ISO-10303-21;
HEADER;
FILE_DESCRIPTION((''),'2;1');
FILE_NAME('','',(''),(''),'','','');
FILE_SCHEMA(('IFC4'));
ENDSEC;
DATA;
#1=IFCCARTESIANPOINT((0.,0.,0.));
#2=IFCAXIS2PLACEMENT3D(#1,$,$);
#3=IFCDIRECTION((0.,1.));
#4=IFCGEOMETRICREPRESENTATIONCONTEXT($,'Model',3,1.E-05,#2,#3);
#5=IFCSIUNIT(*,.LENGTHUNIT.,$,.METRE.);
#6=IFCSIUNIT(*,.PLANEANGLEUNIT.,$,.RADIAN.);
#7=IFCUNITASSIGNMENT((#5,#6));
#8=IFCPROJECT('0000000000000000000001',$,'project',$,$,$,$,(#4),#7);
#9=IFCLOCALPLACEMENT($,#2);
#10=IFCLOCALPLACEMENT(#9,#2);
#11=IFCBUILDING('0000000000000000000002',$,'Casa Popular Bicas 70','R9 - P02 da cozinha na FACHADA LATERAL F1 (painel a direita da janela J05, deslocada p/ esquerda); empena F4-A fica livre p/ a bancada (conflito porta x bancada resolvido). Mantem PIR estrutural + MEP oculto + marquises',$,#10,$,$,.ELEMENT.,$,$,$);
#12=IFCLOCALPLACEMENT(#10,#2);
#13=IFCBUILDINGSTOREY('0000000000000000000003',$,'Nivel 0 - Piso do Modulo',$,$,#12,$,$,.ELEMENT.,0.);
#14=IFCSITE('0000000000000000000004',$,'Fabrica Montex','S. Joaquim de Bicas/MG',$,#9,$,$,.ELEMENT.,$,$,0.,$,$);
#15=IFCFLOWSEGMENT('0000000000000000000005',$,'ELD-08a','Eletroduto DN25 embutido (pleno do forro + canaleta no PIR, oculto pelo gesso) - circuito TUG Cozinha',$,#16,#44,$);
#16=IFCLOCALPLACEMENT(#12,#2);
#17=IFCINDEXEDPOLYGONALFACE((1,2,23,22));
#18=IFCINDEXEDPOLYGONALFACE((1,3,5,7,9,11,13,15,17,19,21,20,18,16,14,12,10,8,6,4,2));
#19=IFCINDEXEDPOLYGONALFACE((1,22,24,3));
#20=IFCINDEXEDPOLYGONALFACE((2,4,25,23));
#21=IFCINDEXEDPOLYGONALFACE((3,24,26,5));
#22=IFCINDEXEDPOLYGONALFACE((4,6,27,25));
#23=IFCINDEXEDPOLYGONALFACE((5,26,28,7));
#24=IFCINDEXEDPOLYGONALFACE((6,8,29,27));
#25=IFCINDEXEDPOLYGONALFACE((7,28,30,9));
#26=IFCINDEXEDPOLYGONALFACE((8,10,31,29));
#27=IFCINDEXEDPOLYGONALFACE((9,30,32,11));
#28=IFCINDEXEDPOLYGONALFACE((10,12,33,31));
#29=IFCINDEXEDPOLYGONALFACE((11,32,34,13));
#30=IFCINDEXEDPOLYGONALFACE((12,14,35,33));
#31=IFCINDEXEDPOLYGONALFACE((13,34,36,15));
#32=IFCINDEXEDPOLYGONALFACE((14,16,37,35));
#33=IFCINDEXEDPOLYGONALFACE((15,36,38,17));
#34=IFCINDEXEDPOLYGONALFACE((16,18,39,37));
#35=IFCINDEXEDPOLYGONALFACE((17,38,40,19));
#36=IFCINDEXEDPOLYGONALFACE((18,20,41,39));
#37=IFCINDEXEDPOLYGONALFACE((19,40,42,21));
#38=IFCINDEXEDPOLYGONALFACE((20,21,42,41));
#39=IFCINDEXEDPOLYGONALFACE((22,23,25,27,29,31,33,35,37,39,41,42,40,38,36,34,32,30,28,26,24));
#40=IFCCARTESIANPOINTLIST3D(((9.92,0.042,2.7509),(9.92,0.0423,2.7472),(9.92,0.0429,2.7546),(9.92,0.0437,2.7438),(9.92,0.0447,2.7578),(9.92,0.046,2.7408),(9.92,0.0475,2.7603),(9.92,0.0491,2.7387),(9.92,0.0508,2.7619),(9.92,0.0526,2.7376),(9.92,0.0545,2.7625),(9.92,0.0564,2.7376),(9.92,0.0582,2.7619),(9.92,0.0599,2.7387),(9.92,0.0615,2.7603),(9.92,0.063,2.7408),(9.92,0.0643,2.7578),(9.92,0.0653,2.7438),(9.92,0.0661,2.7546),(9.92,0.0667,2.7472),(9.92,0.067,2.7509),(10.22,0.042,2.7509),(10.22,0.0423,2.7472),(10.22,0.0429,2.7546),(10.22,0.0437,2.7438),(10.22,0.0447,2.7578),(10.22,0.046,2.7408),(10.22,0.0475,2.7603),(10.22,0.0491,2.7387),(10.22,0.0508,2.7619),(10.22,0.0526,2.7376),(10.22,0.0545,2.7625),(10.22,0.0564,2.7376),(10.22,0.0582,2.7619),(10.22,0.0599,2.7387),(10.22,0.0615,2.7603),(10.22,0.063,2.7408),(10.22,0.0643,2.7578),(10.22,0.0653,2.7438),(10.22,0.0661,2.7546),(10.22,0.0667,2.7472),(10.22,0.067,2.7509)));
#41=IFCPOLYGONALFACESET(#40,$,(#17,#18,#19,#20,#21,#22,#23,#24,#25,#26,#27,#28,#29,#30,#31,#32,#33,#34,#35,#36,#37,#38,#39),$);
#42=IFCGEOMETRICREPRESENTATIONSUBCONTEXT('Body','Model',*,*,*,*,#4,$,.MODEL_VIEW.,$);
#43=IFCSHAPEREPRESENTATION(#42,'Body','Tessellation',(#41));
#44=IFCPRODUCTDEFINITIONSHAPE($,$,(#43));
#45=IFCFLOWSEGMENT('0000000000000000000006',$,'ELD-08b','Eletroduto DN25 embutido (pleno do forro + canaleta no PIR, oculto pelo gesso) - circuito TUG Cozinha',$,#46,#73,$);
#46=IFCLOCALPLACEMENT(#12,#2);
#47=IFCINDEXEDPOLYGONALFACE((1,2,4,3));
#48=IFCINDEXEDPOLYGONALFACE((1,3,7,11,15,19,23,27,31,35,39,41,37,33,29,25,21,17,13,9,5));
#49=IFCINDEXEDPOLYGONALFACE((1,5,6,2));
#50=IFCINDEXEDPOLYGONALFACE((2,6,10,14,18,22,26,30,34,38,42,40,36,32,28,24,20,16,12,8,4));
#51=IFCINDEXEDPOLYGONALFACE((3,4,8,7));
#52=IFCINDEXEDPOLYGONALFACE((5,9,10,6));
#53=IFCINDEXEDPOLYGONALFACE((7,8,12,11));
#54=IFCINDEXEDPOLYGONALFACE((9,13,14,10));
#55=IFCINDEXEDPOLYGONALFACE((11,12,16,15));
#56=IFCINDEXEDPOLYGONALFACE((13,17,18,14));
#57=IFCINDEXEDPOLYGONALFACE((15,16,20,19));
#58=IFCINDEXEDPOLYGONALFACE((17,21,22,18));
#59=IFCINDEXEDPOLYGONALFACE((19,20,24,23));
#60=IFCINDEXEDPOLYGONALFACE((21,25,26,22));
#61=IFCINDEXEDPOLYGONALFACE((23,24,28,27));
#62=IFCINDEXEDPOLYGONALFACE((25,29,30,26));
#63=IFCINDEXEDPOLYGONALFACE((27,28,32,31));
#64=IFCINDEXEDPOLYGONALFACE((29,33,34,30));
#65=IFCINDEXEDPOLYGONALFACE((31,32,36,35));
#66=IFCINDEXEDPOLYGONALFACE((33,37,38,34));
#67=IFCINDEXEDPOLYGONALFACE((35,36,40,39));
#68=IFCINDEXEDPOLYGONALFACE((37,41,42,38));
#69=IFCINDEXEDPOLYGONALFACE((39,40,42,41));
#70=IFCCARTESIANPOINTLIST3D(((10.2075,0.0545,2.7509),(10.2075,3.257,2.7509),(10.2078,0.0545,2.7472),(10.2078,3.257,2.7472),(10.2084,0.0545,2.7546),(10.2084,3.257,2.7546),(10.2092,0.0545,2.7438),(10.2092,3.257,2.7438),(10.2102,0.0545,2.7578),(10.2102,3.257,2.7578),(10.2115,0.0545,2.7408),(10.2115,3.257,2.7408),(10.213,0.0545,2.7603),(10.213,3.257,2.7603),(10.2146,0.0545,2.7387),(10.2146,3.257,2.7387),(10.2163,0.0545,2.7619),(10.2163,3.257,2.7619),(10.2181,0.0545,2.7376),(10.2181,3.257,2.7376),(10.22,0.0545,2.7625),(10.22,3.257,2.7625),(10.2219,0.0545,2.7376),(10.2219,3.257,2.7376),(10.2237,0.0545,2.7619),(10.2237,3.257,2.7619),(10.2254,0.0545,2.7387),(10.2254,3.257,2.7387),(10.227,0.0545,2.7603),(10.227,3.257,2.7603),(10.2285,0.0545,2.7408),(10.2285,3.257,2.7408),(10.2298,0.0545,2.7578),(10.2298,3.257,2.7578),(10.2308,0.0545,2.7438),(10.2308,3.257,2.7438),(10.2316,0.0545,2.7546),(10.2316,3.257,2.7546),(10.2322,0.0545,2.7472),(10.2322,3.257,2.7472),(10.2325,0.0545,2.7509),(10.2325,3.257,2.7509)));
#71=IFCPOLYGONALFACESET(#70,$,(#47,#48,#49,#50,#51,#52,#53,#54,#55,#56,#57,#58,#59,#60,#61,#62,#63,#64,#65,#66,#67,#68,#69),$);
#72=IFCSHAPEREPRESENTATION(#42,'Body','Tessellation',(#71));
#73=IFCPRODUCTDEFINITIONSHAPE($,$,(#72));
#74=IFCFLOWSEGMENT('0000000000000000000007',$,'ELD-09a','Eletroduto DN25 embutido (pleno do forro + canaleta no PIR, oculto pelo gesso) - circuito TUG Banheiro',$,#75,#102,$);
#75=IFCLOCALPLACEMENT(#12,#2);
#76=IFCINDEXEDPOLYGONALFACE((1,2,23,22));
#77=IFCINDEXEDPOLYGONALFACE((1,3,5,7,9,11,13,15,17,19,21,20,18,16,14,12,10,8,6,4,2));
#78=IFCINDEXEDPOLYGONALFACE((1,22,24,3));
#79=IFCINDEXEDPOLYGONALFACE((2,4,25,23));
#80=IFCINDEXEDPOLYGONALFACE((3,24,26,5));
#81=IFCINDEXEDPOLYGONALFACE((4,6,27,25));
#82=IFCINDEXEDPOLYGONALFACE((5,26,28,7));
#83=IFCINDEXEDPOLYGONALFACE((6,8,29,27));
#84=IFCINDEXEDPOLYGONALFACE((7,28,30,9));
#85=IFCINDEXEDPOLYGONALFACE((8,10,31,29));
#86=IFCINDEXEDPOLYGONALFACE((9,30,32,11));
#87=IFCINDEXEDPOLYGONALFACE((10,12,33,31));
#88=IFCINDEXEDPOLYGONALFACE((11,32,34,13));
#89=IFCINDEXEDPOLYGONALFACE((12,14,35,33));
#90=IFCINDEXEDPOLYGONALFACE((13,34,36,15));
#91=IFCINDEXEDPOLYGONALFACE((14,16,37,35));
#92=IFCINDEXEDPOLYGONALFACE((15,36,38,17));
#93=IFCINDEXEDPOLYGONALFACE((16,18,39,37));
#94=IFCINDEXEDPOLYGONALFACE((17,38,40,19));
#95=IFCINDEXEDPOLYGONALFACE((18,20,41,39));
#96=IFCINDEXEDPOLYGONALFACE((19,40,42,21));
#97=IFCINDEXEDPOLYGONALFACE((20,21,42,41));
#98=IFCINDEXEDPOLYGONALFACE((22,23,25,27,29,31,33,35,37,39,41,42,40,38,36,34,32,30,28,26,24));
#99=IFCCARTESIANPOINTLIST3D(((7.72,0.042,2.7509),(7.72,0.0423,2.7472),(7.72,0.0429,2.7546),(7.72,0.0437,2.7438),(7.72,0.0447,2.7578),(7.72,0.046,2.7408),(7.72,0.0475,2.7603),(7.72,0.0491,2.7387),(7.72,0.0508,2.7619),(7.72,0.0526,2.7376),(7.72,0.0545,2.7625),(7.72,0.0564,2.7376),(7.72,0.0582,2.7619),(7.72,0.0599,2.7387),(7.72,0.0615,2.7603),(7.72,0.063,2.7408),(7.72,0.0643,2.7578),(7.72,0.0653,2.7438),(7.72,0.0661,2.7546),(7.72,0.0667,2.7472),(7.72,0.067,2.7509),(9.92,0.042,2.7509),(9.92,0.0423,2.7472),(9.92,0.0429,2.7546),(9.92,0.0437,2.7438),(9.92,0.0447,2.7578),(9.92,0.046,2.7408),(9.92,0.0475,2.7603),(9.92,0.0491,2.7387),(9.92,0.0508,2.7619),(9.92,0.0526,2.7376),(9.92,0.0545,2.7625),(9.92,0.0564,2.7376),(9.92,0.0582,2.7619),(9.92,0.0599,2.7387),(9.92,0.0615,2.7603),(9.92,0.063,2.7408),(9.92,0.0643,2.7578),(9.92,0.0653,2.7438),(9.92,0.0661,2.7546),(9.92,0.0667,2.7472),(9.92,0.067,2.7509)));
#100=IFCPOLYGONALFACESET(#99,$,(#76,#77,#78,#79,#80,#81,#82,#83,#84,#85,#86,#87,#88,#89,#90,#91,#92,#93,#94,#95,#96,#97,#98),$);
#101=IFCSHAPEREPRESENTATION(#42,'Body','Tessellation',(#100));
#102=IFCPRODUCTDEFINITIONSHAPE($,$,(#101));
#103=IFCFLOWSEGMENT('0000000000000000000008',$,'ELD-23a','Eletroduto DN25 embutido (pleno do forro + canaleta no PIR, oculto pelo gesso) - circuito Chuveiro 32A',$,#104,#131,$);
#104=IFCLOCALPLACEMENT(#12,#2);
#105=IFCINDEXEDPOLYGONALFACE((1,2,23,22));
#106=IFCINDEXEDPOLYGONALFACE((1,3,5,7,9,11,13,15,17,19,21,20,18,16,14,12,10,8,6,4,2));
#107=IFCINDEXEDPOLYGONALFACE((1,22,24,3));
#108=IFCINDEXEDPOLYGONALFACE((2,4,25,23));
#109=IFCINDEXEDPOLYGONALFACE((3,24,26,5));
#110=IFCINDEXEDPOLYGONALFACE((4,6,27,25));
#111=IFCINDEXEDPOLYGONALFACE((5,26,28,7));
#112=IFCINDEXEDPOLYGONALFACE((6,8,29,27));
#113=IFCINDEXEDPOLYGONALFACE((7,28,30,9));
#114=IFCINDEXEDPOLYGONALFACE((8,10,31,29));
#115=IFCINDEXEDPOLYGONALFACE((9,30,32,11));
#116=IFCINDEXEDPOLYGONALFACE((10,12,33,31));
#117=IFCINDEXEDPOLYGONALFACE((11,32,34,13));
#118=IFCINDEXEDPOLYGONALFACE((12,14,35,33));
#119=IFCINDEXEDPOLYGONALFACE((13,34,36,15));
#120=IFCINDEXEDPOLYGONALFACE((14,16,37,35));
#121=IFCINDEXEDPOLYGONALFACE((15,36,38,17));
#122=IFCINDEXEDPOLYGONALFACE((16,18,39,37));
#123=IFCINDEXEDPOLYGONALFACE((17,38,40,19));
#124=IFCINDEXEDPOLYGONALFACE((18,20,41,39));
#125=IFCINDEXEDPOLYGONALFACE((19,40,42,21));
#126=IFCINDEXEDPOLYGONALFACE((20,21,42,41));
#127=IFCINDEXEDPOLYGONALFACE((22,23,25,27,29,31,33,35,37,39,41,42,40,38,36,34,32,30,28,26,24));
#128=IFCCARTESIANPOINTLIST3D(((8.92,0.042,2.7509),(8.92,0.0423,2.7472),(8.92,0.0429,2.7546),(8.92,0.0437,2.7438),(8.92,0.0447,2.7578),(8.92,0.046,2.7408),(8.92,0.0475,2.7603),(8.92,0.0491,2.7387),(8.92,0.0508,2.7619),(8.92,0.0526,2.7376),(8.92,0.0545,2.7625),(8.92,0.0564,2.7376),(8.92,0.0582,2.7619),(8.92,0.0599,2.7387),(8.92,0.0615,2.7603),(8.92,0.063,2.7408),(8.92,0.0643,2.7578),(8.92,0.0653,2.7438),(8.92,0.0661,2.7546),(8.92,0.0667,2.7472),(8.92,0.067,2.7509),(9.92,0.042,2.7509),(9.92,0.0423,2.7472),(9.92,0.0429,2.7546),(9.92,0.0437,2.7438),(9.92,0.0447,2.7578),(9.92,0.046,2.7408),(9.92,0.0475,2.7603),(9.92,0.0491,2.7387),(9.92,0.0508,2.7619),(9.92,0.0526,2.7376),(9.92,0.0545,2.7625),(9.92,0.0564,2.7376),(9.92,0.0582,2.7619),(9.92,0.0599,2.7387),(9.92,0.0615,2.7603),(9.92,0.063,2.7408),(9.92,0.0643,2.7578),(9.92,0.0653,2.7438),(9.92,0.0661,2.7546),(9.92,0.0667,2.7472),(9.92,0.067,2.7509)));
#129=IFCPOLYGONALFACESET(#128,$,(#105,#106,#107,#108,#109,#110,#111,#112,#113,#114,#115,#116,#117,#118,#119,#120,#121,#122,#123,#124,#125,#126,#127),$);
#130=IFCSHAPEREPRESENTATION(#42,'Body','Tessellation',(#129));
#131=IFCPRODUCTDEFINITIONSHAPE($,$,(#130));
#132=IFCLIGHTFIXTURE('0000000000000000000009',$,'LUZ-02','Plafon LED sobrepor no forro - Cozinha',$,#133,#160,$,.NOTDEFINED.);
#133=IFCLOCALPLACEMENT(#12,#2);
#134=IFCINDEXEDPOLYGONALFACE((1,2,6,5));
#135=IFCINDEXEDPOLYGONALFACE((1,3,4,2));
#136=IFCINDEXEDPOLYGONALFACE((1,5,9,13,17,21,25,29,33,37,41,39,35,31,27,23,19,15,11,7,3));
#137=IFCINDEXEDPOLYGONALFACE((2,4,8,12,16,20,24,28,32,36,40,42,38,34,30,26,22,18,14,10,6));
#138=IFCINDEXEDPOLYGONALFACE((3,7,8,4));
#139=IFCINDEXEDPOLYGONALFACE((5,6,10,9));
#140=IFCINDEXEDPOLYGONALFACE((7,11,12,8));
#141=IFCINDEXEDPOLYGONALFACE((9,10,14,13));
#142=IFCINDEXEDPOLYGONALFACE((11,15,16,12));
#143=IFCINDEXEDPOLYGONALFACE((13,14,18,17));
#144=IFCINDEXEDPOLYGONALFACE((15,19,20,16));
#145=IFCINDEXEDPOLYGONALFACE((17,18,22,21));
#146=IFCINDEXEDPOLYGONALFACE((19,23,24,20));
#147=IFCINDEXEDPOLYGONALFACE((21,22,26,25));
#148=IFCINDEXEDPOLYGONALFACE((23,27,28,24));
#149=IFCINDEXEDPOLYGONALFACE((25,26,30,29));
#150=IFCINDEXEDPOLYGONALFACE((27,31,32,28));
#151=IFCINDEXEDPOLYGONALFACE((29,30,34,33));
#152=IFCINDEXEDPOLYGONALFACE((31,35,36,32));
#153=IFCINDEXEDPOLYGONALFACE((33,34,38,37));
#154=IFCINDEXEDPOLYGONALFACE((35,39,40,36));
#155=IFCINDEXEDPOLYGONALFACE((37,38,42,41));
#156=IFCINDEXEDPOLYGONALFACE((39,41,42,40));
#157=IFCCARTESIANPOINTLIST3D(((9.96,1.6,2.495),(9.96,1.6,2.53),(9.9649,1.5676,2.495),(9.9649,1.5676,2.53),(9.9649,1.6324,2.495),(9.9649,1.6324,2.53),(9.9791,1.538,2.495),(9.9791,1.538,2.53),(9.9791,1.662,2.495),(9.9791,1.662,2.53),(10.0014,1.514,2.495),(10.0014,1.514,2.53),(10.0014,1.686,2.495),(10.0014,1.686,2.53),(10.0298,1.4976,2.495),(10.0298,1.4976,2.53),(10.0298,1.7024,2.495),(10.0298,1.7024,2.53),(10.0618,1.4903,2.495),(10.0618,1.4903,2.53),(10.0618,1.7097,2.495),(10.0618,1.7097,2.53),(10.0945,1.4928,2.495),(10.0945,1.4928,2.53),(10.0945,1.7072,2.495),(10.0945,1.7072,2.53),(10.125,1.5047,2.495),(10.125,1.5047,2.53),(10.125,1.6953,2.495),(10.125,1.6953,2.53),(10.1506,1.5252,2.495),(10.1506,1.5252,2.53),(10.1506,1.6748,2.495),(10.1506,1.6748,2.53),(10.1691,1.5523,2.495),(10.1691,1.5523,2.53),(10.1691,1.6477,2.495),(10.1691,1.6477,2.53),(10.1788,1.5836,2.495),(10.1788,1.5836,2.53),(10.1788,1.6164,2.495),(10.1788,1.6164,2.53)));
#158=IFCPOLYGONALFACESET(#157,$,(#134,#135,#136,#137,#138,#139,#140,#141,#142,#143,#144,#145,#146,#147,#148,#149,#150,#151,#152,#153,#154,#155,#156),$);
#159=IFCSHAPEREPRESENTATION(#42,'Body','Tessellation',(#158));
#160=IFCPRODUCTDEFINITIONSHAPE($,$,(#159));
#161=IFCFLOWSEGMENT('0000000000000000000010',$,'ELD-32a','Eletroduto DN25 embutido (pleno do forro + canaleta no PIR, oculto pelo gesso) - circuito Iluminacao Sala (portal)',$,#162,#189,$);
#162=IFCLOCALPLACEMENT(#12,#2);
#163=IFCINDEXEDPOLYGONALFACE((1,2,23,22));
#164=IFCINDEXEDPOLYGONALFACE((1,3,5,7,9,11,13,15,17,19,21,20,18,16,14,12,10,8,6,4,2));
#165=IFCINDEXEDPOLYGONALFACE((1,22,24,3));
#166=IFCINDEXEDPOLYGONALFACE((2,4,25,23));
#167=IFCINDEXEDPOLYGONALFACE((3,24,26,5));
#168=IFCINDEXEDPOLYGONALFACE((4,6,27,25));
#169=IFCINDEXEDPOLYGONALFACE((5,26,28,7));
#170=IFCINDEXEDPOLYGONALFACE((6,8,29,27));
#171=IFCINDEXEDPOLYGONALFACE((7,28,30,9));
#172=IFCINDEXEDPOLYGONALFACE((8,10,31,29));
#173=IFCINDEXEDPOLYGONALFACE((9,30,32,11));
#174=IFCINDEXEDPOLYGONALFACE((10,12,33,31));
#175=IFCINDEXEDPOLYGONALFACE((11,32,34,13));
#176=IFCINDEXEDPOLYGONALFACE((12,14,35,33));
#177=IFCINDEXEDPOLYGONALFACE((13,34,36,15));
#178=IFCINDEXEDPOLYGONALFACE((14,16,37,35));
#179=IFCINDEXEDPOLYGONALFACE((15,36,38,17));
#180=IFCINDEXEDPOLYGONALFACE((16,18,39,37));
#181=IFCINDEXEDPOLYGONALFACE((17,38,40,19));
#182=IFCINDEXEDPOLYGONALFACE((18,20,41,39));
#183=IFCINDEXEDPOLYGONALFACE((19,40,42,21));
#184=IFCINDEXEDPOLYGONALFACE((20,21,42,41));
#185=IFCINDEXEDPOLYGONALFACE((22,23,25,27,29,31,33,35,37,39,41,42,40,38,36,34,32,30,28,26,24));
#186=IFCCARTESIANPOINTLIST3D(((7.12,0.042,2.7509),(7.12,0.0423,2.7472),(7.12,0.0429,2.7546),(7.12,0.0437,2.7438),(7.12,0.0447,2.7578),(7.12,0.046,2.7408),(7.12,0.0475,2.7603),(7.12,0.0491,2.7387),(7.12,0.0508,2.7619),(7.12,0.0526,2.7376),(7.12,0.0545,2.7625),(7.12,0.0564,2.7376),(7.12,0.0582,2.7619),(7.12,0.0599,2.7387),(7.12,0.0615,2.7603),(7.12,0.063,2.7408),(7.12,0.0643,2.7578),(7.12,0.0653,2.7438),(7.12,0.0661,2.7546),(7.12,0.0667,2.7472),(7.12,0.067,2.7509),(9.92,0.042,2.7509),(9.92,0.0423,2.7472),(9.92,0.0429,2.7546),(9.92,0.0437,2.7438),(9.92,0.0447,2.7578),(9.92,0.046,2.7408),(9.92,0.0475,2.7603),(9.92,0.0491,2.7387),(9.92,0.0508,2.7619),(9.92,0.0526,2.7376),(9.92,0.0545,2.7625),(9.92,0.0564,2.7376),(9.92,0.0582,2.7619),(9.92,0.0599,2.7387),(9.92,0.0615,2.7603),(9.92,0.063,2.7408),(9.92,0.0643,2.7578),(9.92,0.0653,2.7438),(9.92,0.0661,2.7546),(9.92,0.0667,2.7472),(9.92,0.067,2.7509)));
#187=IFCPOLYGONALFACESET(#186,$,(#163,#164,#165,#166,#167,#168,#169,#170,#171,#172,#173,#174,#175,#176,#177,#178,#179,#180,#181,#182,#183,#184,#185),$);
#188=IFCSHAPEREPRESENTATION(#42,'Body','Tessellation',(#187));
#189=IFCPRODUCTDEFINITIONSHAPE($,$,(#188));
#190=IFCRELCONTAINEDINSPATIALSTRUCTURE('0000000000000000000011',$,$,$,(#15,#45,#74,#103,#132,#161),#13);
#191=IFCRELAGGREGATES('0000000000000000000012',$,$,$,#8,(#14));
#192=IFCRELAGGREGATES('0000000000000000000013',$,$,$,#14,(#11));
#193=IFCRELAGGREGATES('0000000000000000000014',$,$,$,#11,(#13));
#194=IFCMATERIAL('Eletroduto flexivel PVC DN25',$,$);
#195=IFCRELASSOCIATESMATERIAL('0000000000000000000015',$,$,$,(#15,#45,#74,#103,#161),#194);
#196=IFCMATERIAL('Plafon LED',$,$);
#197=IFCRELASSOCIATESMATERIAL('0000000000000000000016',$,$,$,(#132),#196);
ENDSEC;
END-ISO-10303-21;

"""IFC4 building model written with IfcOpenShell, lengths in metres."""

from ifc_helpers import new_model, si_unit, direction, frame, origin, origin_2d, place, context, subcontext, project, spatial, circle, extrude, material, element, save


model = new_model("IFC4")

# Units and contexts
model_context = context("Model", 3, precision=1e-05, world=origin(), true_north=direction((0.0, 1.0)))
body_context = subcontext(model_context, "Body", "Model", "MODEL_VIEW")
ifc_project = project(units=[si_unit("LENGTHUNIT", "METRE"), si_unit("PLANEANGLEUNIT", "RADIAN")], contexts=[model_context])

# Site, building, storey
site_placement = place(None, origin())
site = spatial("IfcSite", under=ifc_project, at=site_placement, Name="Fabrica Montex", Description="S. Joaquim de Bicas/MG", CompositionType="ELEMENT", RefElevation=0.0)
building_placement = place(site_placement, origin())
building = spatial("IfcBuilding", under=site, at=building_placement, Name="Casa Popular Bicas 70", Description="R9 - P02 da cozinha na FACHADA LATERAL F1 (painel a direita da janela J05, deslocada p/ esquerda); empena F4-A fica livre p/ a bancada (conflito porta x bancada resolvido). Mantem PIR estrutural + MEP oculto + marquises", CompositionType="ELEMENT")
storey_placement = place(building_placement, origin())
storey = spatial("IfcBuildingStorey", under=building, at=storey_placement, Name="Nivel 0 - Piso do Modulo", CompositionType="ELEMENT", Elevation=0.0)

# Flow segments
ifc_material_1 = material(Name="Eletroduto flexivel PVC DN25")
flow_segment_1_placement = place(None, frame((9.92, 0.0545, 2.75), z_axis=(1.0, 0.0, 0.0), x_axis=(0.0, 0.0, 1.0)))
element("IfcFlowSegment", 1, at=flow_segment_1_placement, inside=storey, material=ifc_material_1, Name="ELD-08a", Description="Eletroduto DN25 embutido (pleno do forro + canaleta no PIR, oculto pelo gesso) - circuito TUG Cozinha", context=body_context, shape_type="SweptSolid", body=[
    extrude(circle(Radius=0.0125, at=origin_2d()), origin(), (0.0, 0.0, 1.0), 0.3),
])
flow_segment_2_placement = place(None, frame((10.22, 0.0545, 2.75), z_axis=(0.0, 1.0, 0.0), x_axis=(0.0, 0.0, 1.0)))
element("IfcFlowSegment", 2, at=flow_segment_2_placement, inside=storey, material=ifc_material_1, Name="ELD-08b", Description="Eletroduto DN25 embutido (pleno do forro + canaleta no PIR, oculto pelo gesso) - circuito TUG Cozinha", context=body_context, shape_type="SweptSolid", body=[
    extrude(circle(Radius=0.0125, at=origin_2d()), origin(), (0.0, 0.0, 1.0), 3.2025),
])
flow_segment_3_placement = place(None, frame((9.92, 0.0545, 2.75), z_axis=(-1.0, 0.0, 0.0), x_axis=(0.0, 0.0, 1.0)))
element("IfcFlowSegment", 3, at=flow_segment_3_placement, inside=storey, material=ifc_material_1, Name="ELD-09a", Description="Eletroduto DN25 embutido (pleno do forro + canaleta no PIR, oculto pelo gesso) - circuito TUG Banheiro", context=body_context, shape_type="SweptSolid", body=[
    extrude(circle(Radius=0.0125, at=origin_2d()), origin(), (0.0, 0.0, 1.0), 2.2),
])
flow_segment_4_placement = place(None, frame((9.92, 0.0545, 2.75), z_axis=(-1.0, 0.0, 0.0), x_axis=(0.0, 0.0, 1.0)))
element("IfcFlowSegment", 4, at=flow_segment_4_placement, inside=storey, material=ifc_material_1, Name="ELD-23a", Description="Eletroduto DN25 embutido (pleno do forro + canaleta no PIR, oculto pelo gesso) - circuito Chuveiro 32A", context=body_context, shape_type="SweptSolid", body=[
    extrude(circle(Radius=0.0125, at=origin_2d()), origin(), (0.0, 0.0, 1.0), 1.0),
])

# Light fixture
ifc_material_2 = material(Name="Plafon LED")
light_fixture_placement = place(None, frame((10.07, 1.6, 2.495), z_axis=(0.0, 0.0, 1.0), x_axis=(-1.0, 0.0, 0.0)))
element("IfcLightFixture", 5, at=light_fixture_placement, inside=storey, material=ifc_material_2, Name="LUZ-02", Description="Plafon LED sobrepor no forro - Cozinha", PredefinedType="NOTDEFINED", context=body_context, shape_type="SweptSolid", body=[
    extrude(circle(Radius=0.11, at=origin_2d()), origin(), (0.0, 0.0, 1.0), 0.035),
])

# Flow segment
flow_segment_5_placement = place(None, frame((9.92, 0.0545, 2.75), z_axis=(-1.0, 0.0, 0.0), x_axis=(0.0, 0.0, 1.0)))
element("IfcFlowSegment", 6, at=flow_segment_5_placement, inside=storey, material=ifc_material_1, Name="ELD-32a", Description="Eletroduto DN25 embutido (pleno do forro + canaleta no PIR, oculto pelo gesso) - circuito Iluminacao Sala (portal)", context=body_context, shape_type="SweptSolid", body=[
    extrude(circle(Radius=0.0125, at=origin_2d()), origin(), (0.0, 0.0, 1.0), 2.8),
])

save(model, "model.ifc")
